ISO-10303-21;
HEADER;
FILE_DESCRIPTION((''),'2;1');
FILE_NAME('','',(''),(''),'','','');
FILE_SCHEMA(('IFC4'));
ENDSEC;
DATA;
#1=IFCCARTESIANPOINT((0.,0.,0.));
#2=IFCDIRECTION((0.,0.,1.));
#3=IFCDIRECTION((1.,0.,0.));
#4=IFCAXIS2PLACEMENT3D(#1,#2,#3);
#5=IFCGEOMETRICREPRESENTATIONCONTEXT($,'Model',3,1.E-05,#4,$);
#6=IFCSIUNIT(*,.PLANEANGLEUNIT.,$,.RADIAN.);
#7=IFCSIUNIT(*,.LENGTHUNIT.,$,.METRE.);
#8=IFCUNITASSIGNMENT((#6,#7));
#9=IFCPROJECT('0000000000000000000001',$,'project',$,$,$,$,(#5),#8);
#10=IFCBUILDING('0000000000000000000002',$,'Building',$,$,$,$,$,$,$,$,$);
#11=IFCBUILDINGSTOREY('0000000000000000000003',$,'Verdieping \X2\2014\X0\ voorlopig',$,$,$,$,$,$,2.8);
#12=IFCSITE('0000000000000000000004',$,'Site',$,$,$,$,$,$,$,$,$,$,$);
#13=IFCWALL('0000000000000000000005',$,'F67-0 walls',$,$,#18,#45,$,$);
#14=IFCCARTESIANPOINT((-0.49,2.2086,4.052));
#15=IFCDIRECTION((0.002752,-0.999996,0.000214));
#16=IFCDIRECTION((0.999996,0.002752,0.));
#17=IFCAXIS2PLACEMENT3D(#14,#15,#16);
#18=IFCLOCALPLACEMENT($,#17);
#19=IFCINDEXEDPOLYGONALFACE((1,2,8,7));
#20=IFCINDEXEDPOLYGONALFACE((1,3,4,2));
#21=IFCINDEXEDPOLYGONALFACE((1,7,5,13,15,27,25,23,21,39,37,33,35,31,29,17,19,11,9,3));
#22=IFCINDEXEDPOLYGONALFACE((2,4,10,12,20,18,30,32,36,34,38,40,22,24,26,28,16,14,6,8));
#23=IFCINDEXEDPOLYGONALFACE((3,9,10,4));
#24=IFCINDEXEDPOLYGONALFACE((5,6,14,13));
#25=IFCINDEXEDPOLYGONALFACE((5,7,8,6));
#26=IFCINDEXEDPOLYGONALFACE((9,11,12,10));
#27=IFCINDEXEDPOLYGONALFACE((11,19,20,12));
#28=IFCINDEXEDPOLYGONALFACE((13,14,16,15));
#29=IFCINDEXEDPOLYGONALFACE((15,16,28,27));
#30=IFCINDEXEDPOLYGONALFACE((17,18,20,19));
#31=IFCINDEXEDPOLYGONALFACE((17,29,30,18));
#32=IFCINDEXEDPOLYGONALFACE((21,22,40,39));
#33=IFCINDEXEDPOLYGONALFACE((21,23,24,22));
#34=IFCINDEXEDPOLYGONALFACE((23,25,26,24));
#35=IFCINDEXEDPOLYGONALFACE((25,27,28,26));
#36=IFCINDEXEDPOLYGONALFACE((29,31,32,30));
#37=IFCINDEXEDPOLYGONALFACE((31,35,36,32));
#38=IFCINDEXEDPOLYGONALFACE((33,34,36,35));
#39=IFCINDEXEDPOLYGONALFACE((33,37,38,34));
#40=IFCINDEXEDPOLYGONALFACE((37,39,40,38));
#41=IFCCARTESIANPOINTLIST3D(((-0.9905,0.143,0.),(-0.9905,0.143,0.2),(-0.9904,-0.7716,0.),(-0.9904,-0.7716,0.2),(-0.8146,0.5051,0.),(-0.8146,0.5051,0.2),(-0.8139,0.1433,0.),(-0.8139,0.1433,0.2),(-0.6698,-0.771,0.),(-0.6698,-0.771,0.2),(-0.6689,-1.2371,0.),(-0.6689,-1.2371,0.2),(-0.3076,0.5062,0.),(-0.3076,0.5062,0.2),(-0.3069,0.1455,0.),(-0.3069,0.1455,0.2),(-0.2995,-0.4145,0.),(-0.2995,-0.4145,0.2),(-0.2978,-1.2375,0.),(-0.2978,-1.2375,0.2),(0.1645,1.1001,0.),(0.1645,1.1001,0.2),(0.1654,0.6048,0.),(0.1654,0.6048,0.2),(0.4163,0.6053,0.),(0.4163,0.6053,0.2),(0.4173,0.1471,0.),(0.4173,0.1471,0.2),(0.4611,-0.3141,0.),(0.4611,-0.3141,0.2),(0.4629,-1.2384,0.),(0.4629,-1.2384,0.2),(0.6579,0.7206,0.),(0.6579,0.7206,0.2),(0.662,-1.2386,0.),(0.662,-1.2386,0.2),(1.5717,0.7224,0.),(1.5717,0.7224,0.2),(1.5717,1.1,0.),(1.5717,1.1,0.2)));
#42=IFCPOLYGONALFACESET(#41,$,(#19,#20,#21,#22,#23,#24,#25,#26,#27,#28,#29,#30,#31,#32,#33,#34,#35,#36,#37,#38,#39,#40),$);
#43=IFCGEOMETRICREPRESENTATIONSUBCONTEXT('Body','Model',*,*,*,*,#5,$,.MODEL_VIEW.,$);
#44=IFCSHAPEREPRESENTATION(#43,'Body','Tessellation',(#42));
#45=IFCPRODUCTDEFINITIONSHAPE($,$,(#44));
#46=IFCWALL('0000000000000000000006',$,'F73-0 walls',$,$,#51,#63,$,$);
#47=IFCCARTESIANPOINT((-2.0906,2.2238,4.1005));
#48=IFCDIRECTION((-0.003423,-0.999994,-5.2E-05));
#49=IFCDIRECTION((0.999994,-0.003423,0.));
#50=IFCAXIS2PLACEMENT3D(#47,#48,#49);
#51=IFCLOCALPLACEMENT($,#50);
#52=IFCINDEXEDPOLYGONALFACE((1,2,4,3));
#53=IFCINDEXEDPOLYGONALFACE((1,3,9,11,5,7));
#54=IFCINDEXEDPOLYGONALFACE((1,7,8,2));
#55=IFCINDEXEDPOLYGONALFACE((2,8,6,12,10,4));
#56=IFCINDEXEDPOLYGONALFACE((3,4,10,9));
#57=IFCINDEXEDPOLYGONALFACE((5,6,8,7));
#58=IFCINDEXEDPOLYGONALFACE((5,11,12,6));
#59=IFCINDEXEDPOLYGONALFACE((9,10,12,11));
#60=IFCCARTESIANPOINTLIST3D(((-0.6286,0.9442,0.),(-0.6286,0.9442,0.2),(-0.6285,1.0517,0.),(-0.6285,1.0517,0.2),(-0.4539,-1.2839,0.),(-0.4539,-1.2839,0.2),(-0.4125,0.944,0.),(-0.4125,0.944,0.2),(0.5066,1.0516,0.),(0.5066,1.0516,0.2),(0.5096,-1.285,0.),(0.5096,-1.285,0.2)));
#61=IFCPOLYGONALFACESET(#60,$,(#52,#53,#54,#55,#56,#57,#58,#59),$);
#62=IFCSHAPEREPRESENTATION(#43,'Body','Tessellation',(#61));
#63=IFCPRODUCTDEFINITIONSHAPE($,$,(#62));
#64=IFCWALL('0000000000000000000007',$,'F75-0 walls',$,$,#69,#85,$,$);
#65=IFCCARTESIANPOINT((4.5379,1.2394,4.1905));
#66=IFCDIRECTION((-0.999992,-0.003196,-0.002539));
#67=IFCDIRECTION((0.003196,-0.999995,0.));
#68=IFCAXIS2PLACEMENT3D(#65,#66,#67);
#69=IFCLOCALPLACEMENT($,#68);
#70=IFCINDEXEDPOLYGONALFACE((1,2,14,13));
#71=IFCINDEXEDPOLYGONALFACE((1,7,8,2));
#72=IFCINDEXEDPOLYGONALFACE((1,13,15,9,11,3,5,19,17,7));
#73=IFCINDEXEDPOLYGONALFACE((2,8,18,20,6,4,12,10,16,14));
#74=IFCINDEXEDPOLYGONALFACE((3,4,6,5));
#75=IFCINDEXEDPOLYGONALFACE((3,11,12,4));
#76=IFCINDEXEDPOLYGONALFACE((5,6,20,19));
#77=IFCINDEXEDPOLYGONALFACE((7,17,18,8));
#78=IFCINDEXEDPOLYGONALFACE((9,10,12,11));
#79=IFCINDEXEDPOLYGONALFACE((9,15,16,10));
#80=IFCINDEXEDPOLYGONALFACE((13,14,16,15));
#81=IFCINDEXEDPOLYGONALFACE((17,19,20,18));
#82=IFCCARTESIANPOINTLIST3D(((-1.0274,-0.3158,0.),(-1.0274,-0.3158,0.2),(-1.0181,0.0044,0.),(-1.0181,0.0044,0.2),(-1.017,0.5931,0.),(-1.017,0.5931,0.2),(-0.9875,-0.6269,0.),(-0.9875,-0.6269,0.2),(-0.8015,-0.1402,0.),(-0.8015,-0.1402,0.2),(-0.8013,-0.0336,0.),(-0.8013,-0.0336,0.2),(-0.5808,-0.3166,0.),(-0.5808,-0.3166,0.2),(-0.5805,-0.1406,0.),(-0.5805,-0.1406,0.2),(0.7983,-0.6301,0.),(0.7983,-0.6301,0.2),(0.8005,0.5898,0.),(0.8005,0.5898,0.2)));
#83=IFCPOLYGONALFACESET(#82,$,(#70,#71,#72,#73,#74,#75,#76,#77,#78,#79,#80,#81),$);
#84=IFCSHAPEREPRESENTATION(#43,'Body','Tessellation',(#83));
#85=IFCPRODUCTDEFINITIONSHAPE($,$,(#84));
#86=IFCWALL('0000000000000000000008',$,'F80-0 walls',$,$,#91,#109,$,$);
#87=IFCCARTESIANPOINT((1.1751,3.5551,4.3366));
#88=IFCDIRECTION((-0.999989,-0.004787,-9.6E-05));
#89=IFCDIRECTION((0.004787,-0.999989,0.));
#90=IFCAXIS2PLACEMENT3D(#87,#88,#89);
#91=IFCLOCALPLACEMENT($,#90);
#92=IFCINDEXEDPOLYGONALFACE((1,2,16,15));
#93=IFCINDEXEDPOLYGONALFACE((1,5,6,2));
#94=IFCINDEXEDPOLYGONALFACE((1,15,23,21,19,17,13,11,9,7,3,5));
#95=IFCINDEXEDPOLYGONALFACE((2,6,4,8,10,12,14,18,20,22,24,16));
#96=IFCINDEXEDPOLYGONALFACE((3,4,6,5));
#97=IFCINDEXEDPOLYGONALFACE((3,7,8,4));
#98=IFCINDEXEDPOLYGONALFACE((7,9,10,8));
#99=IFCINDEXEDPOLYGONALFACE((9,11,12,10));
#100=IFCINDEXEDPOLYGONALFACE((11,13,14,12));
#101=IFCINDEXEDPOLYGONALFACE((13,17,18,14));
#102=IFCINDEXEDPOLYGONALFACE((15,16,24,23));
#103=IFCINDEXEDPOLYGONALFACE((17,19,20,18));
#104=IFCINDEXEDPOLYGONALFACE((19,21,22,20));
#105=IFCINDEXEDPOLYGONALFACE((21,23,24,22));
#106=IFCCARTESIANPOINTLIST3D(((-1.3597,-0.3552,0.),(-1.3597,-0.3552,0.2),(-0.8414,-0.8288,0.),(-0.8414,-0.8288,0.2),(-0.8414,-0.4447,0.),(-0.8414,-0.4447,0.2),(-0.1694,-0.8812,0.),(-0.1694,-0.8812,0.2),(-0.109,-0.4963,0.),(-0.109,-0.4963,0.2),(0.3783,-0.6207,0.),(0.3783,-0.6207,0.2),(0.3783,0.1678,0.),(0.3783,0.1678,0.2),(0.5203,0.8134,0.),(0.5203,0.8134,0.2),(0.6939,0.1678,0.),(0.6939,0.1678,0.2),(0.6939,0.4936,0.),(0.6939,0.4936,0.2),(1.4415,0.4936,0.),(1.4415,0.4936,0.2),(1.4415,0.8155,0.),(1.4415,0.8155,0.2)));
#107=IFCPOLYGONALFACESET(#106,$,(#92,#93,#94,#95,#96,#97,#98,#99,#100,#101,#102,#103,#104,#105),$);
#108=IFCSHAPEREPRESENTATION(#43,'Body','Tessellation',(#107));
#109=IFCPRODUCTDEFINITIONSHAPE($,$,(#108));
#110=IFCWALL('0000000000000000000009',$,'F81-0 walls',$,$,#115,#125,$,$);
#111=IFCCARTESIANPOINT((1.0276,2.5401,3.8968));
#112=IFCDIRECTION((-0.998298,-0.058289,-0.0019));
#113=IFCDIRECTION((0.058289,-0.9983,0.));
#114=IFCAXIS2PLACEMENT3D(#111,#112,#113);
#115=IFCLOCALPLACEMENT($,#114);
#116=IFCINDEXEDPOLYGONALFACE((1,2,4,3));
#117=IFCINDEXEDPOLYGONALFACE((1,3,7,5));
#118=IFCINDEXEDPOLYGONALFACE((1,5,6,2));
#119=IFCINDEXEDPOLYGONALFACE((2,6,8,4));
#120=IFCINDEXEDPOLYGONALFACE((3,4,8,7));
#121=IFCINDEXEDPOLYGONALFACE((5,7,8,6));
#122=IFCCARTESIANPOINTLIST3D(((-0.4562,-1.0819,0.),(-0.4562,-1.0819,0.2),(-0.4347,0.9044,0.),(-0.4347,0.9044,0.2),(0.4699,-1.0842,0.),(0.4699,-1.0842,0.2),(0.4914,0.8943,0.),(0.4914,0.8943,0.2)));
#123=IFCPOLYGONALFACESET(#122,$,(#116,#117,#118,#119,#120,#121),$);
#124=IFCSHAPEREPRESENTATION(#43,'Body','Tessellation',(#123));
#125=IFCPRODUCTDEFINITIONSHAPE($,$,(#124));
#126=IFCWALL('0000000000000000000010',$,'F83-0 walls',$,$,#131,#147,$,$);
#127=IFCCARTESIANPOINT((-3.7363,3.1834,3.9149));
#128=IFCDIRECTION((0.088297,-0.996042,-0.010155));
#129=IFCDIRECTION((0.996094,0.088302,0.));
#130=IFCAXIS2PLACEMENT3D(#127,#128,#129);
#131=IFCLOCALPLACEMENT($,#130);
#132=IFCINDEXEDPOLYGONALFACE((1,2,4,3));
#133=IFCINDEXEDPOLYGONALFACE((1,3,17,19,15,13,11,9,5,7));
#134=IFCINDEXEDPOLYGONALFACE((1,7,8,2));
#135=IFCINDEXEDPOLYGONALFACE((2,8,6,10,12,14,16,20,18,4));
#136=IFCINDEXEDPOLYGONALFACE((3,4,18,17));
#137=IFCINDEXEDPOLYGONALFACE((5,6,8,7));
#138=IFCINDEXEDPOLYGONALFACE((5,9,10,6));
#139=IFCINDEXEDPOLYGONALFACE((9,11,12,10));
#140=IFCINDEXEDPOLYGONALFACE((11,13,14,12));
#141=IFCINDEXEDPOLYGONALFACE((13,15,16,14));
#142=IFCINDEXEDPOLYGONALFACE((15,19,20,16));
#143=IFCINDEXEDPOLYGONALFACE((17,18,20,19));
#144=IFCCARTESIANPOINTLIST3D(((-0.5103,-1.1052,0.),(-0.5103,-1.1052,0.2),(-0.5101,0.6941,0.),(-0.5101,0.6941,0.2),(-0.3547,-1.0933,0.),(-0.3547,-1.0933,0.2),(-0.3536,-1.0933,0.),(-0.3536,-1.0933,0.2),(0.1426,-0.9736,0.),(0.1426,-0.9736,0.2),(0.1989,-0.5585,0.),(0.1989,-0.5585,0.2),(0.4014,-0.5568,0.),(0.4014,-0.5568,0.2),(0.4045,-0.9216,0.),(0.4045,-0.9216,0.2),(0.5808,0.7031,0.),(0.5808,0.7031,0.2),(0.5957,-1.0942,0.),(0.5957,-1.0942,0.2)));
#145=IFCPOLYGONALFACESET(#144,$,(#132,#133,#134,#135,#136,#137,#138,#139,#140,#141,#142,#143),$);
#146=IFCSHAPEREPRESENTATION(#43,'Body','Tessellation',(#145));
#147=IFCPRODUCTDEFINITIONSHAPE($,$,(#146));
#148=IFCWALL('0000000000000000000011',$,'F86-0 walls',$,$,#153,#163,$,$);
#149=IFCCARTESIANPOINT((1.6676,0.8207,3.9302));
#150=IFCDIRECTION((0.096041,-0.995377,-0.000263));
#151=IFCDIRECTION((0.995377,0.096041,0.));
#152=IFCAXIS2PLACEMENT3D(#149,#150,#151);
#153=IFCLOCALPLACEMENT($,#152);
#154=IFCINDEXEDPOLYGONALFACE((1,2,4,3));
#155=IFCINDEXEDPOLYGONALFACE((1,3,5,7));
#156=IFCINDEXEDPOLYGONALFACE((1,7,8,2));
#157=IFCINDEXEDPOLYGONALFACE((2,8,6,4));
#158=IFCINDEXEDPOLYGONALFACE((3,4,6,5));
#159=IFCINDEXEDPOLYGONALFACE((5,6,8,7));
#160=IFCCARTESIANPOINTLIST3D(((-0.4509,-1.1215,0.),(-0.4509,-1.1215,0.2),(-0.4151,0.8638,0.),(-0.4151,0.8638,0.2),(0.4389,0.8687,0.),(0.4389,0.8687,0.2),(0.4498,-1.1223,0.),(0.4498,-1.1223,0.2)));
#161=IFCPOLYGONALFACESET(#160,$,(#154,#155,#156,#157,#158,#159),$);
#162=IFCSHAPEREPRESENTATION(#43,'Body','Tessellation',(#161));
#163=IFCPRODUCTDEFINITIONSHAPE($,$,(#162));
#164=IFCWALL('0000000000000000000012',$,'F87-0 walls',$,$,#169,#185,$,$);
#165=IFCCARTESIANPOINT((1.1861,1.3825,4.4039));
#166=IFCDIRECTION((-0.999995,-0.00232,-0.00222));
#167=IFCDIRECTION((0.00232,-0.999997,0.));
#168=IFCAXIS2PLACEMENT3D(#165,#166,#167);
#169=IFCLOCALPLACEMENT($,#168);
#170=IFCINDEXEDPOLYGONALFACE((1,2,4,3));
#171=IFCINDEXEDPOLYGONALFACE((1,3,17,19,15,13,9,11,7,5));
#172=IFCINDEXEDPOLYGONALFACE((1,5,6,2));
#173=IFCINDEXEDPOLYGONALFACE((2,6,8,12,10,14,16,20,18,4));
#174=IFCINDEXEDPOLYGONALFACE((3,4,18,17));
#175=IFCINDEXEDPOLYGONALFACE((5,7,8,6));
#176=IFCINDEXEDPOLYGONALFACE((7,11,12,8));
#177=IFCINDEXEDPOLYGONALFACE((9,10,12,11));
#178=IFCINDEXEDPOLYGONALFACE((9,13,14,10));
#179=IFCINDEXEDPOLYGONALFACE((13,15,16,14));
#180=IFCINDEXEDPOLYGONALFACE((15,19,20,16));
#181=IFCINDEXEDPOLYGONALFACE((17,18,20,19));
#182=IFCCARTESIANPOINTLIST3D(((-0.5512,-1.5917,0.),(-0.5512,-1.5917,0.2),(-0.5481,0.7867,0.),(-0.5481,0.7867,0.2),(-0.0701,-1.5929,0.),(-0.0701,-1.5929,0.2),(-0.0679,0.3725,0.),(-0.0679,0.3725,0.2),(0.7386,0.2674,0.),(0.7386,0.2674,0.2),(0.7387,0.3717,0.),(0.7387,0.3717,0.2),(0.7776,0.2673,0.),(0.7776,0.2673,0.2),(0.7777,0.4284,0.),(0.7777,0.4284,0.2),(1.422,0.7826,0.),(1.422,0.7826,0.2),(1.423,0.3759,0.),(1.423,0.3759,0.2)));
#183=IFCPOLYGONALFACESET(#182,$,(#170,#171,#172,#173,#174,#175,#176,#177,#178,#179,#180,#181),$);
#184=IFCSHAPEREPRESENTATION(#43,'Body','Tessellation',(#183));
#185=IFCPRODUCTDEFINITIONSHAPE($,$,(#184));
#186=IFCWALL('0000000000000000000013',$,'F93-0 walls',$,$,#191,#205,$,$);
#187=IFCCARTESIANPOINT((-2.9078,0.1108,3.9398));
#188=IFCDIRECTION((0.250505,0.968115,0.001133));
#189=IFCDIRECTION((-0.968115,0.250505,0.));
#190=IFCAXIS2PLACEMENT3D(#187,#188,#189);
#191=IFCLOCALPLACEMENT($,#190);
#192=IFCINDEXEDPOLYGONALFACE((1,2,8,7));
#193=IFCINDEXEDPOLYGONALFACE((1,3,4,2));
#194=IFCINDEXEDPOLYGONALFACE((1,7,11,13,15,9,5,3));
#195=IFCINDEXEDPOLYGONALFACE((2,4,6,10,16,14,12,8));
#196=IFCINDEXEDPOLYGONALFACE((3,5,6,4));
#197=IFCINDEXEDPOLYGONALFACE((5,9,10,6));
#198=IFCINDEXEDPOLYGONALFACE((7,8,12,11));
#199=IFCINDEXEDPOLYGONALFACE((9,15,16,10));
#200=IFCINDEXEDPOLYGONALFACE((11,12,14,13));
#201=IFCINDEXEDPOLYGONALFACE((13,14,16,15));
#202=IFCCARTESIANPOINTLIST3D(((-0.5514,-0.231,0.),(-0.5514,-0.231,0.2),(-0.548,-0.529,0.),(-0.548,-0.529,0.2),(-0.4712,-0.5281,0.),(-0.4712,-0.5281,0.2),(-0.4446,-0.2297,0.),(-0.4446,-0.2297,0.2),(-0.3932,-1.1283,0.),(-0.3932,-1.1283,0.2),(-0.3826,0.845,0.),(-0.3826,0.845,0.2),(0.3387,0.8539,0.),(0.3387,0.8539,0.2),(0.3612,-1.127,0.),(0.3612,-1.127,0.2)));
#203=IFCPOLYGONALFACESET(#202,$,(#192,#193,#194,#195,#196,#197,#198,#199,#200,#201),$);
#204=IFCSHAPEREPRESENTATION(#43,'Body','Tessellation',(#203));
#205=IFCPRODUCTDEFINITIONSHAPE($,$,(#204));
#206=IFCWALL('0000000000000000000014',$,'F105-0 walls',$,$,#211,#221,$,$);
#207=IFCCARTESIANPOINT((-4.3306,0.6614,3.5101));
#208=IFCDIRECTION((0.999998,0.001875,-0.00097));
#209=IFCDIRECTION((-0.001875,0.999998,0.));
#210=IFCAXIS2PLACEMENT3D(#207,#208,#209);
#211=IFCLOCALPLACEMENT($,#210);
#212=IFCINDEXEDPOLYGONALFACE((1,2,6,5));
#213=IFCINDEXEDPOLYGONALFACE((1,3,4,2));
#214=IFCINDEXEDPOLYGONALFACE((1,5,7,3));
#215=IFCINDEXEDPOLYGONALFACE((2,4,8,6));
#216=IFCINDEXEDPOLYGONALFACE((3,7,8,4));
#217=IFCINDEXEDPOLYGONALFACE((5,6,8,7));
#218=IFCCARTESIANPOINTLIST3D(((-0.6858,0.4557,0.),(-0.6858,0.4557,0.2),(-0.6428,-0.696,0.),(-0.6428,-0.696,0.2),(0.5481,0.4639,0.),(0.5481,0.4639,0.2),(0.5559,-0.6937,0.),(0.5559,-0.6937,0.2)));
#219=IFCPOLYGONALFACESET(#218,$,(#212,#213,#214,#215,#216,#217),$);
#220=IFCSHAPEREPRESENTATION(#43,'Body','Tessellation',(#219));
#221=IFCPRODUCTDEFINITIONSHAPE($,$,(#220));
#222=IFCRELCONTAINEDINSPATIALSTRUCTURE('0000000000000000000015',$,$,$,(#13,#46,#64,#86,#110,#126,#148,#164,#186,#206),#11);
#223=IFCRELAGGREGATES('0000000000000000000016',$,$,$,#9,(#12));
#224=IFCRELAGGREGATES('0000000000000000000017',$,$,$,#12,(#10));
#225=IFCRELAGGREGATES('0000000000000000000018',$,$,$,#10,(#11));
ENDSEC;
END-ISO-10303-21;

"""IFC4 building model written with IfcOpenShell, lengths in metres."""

from ifc_helpers import new_model, si_unit, frame, origin_with_axes, place, context, subcontext, project, spatial, polyline, outline, extrude, element, save


model = new_model("IFC4")

# Units and contexts
model_context = context("Model", 3, precision=1e-05, world=origin_with_axes())
body_context = subcontext(model_context, "Body", "Model", "MODEL_VIEW")
ifc_project = project(units=[si_unit("PLANEANGLEUNIT", "RADIAN"), si_unit("LENGTHUNIT", "METRE")], contexts=[model_context])

# Site, building, storey
site = spatial("IfcSite", under=ifc_project, Name="Site")
building = spatial("IfcBuilding", under=site, Name="Building")
storey = spatial("IfcBuildingStorey", under=building, Name="Verdieping — voorlopig", Elevation=2.8)

# Walls
wall_1_placement = place(None, frame((-0.49, 2.2086, 4.052), z_axis=(0.002752, -0.999996, 0.000214), x_axis=(0.999996, 0.002752, 0.0)))
element("IfcWall", 1, at=wall_1_placement, inside=storey, Name="F67-0 walls", context=body_context, shape_type="SweptSolid", body=[
    extrude(outline(polyline([(-0.6689, -1.2371), (-0.2978, -1.2375), (-0.2995, -0.4145), (0.4611, -0.3141), (0.4629, -1.2384), (0.662, -1.2386), (0.6579, 0.7206), (1.5717, 0.7224), (1.5717, 1.1), (0.1645, 1.1001), (0.1654, 0.6048), (0.4163, 0.6053), (0.4173, 0.1471), (-0.3069, 0.1455), (-0.3076, 0.5062), (-0.8146, 0.5051), (-0.8139, 0.1433), (-0.9905, 0.143), (-0.9904, -0.7716), (-0.6698, -0.771), (-0.6689, -1.2371)])), origin_with_axes(), (0.0, 0.0, 1.0), 0.2),
])
wall_2_placement = place(None, frame((-2.0906, 2.2238, 4.1005), z_axis=(-0.003423, -0.999994, -0.000052), x_axis=(0.999994, -0.003423, 0.0)))
element("IfcWall", 2, at=wall_2_placement, inside=storey, Name="F73-0 walls", context=body_context, shape_type="SweptSolid", body=[
    extrude(outline(polyline([(-0.4539, -1.2839), (0.5096, -1.285), (0.5066, 1.0516), (-0.6285, 1.0517), (-0.6286, 0.9442), (-0.4125, 0.944), (-0.4539, -1.2839)])), origin_with_axes(), (0.0, 0.0, 1.0), 0.2),
])
wall_3_placement = place(None, frame((4.5379, 1.2394, 4.1905), z_axis=(-0.999992, -0.003196, -0.002539), x_axis=(0.003196, -0.999995, 0.0)))
element("IfcWall", 3, at=wall_3_placement, inside=storey, Name="F75-0 walls", context=body_context, shape_type="SweptSolid", body=[
    extrude(outline(polyline([(-0.9875, -0.6269), (0.7983, -0.6301), (0.8005, 0.5898), (-1.017, 0.5931), (-1.0181, 0.0044), (-0.8013, -0.0336), (-0.8015, -0.1402), (-0.5805, -0.1406), (-0.5808, -0.3166), (-1.0274, -0.3158), (-0.9875, -0.6269)])), origin_with_axes(), (0.0, 0.0, 1.0), 0.2),
])
wall_4_placement = place(None, frame((1.1751, 3.5551, 4.3366), z_axis=(-0.999989, -0.004787, -0.000096), x_axis=(0.004787, -0.999989, 0.0)))
element("IfcWall", 4, at=wall_4_placement, inside=storey, Name="F80-0 walls", context=body_context, shape_type="SweptSolid", body=[
    extrude(outline(polyline([(-0.1694, -0.8812), (-0.109, -0.4963), (0.3783, -0.6207), (0.3783, 0.1678), (0.6939, 0.1678), (0.6939, 0.4936), (1.4415, 0.4936), (1.4415, 0.8155), (0.5203, 0.8134), (-1.3597, -0.3552), (-0.8414, -0.4447), (-0.8414, -0.8288), (-0.1694, -0.8812)])), origin_with_axes(), (0.0, 0.0, 1.0), 0.2),
])
wall_5_placement = place(None, frame((1.0276, 2.5401, 3.8968), z_axis=(-0.998298, -0.058289, -0.0019), x_axis=(0.058289, -0.9983, 0.0)))
element("IfcWall", 5, at=wall_5_placement, inside=storey, Name="F81-0 walls", context=body_context, shape_type="SweptSolid", body=[
    extrude(outline(polyline([(-0.4562, -1.0819), (0.4699, -1.0842), (0.4914, 0.8943), (-0.4347, 0.9044), (-0.4562, -1.0819)])), origin_with_axes(), (0.0, 0.0, 1.0), 0.2),
])
wall_6_placement = place(None, frame((-3.7363, 3.1834, 3.9149), z_axis=(0.088297, -0.996042, -0.010155), x_axis=(0.996094, 0.088302, 0.0)))
element("IfcWall", 6, at=wall_6_placement, inside=storey, Name="F83-0 walls", context=body_context, shape_type="SweptSolid", body=[
    extrude(outline(polyline([(-0.5103, -1.1052), (-0.3536, -1.0933), (-0.3547, -1.0933), (0.1426, -0.9736), (0.1989, -0.5585), (0.4014, -0.5568), (0.4045, -0.9216), (0.5957, -1.0942), (0.5808, 0.7031), (-0.5101, 0.6941), (-0.5103, -1.1052)])), origin_with_axes(), (0.0, 0.0, 1.0), 0.2),
])
wall_7_placement = place(None, frame((1.6676, 0.8207, 3.9302), z_axis=(0.096041, -0.995377, -0.000263), x_axis=(0.995377, 0.096041, 0.0)))
element("IfcWall", 7, at=wall_7_placement, inside=storey, Name="F86-0 walls", context=body_context, shape_type="SweptSolid", body=[
    extrude(outline(polyline([(-0.4509, -1.1215), (0.4498, -1.1223), (0.4389, 0.8687), (-0.4151, 0.8638), (-0.4509, -1.1215)])), origin_with_axes(), (0.0, 0.0, 1.0), 0.2),
])
wall_8_placement = place(None, frame((1.1861, 1.3825, 4.4039), z_axis=(-0.999995, -0.00232, -0.00222), x_axis=(0.00232, -0.999997, 0.0)))
element("IfcWall", 8, at=wall_8_placement, inside=storey, Name="F87-0 walls", context=body_context, shape_type="SweptSolid", body=[
    extrude(outline(polyline([(-0.0701, -1.5929), (-0.0679, 0.3725), (0.7387, 0.3717), (0.7386, 0.2674), (0.7776, 0.2673), (0.7777, 0.4284), (1.423, 0.3759), (1.422, 0.7826), (-0.5481, 0.7867), (-0.5512, -1.5917), (-0.0701, -1.5929)])), origin_with_axes(), (0.0, 0.0, 1.0), 0.2),
])
wall_9_placement = place(None, frame((-2.9078, 0.1108, 3.9398), z_axis=(0.250505, 0.968115, 0.001133), x_axis=(-0.968115, 0.250505, 0.0)))
element("IfcWall", 9, at=wall_9_placement, inside=storey, Name="F93-0 walls", context=body_context, shape_type="SweptSolid", body=[
    extrude(outline(polyline([(-0.3932, -1.1283), (0.3612, -1.127), (0.3387, 0.8539), (-0.3826, 0.845), (-0.4446, -0.2297), (-0.5514, -0.231), (-0.548, -0.529), (-0.4712, -0.5281), (-0.3932, -1.1283)])), origin_with_axes(), (0.0, 0.0, 1.0), 0.2),
])
wall_10_placement = place(None, frame((-4.3306, 0.6614, 3.5101), z_axis=(0.999998, 0.001875, -0.00097), x_axis=(-0.001875, 0.999998, 0.0)))
element("IfcWall", 10, at=wall_10_placement, inside=storey, Name="F105-0 walls", context=body_context, shape_type="SweptSolid", body=[
    extrude(outline(polyline([(-0.6428, -0.696), (0.5559, -0.6937), (0.5481, 0.4639), (-0.6858, 0.4557), (-0.6428, -0.696)])), origin_with_axes(), (0.0, 0.0, 1.0), 0.2),
])

save(model, "model.ifc")
